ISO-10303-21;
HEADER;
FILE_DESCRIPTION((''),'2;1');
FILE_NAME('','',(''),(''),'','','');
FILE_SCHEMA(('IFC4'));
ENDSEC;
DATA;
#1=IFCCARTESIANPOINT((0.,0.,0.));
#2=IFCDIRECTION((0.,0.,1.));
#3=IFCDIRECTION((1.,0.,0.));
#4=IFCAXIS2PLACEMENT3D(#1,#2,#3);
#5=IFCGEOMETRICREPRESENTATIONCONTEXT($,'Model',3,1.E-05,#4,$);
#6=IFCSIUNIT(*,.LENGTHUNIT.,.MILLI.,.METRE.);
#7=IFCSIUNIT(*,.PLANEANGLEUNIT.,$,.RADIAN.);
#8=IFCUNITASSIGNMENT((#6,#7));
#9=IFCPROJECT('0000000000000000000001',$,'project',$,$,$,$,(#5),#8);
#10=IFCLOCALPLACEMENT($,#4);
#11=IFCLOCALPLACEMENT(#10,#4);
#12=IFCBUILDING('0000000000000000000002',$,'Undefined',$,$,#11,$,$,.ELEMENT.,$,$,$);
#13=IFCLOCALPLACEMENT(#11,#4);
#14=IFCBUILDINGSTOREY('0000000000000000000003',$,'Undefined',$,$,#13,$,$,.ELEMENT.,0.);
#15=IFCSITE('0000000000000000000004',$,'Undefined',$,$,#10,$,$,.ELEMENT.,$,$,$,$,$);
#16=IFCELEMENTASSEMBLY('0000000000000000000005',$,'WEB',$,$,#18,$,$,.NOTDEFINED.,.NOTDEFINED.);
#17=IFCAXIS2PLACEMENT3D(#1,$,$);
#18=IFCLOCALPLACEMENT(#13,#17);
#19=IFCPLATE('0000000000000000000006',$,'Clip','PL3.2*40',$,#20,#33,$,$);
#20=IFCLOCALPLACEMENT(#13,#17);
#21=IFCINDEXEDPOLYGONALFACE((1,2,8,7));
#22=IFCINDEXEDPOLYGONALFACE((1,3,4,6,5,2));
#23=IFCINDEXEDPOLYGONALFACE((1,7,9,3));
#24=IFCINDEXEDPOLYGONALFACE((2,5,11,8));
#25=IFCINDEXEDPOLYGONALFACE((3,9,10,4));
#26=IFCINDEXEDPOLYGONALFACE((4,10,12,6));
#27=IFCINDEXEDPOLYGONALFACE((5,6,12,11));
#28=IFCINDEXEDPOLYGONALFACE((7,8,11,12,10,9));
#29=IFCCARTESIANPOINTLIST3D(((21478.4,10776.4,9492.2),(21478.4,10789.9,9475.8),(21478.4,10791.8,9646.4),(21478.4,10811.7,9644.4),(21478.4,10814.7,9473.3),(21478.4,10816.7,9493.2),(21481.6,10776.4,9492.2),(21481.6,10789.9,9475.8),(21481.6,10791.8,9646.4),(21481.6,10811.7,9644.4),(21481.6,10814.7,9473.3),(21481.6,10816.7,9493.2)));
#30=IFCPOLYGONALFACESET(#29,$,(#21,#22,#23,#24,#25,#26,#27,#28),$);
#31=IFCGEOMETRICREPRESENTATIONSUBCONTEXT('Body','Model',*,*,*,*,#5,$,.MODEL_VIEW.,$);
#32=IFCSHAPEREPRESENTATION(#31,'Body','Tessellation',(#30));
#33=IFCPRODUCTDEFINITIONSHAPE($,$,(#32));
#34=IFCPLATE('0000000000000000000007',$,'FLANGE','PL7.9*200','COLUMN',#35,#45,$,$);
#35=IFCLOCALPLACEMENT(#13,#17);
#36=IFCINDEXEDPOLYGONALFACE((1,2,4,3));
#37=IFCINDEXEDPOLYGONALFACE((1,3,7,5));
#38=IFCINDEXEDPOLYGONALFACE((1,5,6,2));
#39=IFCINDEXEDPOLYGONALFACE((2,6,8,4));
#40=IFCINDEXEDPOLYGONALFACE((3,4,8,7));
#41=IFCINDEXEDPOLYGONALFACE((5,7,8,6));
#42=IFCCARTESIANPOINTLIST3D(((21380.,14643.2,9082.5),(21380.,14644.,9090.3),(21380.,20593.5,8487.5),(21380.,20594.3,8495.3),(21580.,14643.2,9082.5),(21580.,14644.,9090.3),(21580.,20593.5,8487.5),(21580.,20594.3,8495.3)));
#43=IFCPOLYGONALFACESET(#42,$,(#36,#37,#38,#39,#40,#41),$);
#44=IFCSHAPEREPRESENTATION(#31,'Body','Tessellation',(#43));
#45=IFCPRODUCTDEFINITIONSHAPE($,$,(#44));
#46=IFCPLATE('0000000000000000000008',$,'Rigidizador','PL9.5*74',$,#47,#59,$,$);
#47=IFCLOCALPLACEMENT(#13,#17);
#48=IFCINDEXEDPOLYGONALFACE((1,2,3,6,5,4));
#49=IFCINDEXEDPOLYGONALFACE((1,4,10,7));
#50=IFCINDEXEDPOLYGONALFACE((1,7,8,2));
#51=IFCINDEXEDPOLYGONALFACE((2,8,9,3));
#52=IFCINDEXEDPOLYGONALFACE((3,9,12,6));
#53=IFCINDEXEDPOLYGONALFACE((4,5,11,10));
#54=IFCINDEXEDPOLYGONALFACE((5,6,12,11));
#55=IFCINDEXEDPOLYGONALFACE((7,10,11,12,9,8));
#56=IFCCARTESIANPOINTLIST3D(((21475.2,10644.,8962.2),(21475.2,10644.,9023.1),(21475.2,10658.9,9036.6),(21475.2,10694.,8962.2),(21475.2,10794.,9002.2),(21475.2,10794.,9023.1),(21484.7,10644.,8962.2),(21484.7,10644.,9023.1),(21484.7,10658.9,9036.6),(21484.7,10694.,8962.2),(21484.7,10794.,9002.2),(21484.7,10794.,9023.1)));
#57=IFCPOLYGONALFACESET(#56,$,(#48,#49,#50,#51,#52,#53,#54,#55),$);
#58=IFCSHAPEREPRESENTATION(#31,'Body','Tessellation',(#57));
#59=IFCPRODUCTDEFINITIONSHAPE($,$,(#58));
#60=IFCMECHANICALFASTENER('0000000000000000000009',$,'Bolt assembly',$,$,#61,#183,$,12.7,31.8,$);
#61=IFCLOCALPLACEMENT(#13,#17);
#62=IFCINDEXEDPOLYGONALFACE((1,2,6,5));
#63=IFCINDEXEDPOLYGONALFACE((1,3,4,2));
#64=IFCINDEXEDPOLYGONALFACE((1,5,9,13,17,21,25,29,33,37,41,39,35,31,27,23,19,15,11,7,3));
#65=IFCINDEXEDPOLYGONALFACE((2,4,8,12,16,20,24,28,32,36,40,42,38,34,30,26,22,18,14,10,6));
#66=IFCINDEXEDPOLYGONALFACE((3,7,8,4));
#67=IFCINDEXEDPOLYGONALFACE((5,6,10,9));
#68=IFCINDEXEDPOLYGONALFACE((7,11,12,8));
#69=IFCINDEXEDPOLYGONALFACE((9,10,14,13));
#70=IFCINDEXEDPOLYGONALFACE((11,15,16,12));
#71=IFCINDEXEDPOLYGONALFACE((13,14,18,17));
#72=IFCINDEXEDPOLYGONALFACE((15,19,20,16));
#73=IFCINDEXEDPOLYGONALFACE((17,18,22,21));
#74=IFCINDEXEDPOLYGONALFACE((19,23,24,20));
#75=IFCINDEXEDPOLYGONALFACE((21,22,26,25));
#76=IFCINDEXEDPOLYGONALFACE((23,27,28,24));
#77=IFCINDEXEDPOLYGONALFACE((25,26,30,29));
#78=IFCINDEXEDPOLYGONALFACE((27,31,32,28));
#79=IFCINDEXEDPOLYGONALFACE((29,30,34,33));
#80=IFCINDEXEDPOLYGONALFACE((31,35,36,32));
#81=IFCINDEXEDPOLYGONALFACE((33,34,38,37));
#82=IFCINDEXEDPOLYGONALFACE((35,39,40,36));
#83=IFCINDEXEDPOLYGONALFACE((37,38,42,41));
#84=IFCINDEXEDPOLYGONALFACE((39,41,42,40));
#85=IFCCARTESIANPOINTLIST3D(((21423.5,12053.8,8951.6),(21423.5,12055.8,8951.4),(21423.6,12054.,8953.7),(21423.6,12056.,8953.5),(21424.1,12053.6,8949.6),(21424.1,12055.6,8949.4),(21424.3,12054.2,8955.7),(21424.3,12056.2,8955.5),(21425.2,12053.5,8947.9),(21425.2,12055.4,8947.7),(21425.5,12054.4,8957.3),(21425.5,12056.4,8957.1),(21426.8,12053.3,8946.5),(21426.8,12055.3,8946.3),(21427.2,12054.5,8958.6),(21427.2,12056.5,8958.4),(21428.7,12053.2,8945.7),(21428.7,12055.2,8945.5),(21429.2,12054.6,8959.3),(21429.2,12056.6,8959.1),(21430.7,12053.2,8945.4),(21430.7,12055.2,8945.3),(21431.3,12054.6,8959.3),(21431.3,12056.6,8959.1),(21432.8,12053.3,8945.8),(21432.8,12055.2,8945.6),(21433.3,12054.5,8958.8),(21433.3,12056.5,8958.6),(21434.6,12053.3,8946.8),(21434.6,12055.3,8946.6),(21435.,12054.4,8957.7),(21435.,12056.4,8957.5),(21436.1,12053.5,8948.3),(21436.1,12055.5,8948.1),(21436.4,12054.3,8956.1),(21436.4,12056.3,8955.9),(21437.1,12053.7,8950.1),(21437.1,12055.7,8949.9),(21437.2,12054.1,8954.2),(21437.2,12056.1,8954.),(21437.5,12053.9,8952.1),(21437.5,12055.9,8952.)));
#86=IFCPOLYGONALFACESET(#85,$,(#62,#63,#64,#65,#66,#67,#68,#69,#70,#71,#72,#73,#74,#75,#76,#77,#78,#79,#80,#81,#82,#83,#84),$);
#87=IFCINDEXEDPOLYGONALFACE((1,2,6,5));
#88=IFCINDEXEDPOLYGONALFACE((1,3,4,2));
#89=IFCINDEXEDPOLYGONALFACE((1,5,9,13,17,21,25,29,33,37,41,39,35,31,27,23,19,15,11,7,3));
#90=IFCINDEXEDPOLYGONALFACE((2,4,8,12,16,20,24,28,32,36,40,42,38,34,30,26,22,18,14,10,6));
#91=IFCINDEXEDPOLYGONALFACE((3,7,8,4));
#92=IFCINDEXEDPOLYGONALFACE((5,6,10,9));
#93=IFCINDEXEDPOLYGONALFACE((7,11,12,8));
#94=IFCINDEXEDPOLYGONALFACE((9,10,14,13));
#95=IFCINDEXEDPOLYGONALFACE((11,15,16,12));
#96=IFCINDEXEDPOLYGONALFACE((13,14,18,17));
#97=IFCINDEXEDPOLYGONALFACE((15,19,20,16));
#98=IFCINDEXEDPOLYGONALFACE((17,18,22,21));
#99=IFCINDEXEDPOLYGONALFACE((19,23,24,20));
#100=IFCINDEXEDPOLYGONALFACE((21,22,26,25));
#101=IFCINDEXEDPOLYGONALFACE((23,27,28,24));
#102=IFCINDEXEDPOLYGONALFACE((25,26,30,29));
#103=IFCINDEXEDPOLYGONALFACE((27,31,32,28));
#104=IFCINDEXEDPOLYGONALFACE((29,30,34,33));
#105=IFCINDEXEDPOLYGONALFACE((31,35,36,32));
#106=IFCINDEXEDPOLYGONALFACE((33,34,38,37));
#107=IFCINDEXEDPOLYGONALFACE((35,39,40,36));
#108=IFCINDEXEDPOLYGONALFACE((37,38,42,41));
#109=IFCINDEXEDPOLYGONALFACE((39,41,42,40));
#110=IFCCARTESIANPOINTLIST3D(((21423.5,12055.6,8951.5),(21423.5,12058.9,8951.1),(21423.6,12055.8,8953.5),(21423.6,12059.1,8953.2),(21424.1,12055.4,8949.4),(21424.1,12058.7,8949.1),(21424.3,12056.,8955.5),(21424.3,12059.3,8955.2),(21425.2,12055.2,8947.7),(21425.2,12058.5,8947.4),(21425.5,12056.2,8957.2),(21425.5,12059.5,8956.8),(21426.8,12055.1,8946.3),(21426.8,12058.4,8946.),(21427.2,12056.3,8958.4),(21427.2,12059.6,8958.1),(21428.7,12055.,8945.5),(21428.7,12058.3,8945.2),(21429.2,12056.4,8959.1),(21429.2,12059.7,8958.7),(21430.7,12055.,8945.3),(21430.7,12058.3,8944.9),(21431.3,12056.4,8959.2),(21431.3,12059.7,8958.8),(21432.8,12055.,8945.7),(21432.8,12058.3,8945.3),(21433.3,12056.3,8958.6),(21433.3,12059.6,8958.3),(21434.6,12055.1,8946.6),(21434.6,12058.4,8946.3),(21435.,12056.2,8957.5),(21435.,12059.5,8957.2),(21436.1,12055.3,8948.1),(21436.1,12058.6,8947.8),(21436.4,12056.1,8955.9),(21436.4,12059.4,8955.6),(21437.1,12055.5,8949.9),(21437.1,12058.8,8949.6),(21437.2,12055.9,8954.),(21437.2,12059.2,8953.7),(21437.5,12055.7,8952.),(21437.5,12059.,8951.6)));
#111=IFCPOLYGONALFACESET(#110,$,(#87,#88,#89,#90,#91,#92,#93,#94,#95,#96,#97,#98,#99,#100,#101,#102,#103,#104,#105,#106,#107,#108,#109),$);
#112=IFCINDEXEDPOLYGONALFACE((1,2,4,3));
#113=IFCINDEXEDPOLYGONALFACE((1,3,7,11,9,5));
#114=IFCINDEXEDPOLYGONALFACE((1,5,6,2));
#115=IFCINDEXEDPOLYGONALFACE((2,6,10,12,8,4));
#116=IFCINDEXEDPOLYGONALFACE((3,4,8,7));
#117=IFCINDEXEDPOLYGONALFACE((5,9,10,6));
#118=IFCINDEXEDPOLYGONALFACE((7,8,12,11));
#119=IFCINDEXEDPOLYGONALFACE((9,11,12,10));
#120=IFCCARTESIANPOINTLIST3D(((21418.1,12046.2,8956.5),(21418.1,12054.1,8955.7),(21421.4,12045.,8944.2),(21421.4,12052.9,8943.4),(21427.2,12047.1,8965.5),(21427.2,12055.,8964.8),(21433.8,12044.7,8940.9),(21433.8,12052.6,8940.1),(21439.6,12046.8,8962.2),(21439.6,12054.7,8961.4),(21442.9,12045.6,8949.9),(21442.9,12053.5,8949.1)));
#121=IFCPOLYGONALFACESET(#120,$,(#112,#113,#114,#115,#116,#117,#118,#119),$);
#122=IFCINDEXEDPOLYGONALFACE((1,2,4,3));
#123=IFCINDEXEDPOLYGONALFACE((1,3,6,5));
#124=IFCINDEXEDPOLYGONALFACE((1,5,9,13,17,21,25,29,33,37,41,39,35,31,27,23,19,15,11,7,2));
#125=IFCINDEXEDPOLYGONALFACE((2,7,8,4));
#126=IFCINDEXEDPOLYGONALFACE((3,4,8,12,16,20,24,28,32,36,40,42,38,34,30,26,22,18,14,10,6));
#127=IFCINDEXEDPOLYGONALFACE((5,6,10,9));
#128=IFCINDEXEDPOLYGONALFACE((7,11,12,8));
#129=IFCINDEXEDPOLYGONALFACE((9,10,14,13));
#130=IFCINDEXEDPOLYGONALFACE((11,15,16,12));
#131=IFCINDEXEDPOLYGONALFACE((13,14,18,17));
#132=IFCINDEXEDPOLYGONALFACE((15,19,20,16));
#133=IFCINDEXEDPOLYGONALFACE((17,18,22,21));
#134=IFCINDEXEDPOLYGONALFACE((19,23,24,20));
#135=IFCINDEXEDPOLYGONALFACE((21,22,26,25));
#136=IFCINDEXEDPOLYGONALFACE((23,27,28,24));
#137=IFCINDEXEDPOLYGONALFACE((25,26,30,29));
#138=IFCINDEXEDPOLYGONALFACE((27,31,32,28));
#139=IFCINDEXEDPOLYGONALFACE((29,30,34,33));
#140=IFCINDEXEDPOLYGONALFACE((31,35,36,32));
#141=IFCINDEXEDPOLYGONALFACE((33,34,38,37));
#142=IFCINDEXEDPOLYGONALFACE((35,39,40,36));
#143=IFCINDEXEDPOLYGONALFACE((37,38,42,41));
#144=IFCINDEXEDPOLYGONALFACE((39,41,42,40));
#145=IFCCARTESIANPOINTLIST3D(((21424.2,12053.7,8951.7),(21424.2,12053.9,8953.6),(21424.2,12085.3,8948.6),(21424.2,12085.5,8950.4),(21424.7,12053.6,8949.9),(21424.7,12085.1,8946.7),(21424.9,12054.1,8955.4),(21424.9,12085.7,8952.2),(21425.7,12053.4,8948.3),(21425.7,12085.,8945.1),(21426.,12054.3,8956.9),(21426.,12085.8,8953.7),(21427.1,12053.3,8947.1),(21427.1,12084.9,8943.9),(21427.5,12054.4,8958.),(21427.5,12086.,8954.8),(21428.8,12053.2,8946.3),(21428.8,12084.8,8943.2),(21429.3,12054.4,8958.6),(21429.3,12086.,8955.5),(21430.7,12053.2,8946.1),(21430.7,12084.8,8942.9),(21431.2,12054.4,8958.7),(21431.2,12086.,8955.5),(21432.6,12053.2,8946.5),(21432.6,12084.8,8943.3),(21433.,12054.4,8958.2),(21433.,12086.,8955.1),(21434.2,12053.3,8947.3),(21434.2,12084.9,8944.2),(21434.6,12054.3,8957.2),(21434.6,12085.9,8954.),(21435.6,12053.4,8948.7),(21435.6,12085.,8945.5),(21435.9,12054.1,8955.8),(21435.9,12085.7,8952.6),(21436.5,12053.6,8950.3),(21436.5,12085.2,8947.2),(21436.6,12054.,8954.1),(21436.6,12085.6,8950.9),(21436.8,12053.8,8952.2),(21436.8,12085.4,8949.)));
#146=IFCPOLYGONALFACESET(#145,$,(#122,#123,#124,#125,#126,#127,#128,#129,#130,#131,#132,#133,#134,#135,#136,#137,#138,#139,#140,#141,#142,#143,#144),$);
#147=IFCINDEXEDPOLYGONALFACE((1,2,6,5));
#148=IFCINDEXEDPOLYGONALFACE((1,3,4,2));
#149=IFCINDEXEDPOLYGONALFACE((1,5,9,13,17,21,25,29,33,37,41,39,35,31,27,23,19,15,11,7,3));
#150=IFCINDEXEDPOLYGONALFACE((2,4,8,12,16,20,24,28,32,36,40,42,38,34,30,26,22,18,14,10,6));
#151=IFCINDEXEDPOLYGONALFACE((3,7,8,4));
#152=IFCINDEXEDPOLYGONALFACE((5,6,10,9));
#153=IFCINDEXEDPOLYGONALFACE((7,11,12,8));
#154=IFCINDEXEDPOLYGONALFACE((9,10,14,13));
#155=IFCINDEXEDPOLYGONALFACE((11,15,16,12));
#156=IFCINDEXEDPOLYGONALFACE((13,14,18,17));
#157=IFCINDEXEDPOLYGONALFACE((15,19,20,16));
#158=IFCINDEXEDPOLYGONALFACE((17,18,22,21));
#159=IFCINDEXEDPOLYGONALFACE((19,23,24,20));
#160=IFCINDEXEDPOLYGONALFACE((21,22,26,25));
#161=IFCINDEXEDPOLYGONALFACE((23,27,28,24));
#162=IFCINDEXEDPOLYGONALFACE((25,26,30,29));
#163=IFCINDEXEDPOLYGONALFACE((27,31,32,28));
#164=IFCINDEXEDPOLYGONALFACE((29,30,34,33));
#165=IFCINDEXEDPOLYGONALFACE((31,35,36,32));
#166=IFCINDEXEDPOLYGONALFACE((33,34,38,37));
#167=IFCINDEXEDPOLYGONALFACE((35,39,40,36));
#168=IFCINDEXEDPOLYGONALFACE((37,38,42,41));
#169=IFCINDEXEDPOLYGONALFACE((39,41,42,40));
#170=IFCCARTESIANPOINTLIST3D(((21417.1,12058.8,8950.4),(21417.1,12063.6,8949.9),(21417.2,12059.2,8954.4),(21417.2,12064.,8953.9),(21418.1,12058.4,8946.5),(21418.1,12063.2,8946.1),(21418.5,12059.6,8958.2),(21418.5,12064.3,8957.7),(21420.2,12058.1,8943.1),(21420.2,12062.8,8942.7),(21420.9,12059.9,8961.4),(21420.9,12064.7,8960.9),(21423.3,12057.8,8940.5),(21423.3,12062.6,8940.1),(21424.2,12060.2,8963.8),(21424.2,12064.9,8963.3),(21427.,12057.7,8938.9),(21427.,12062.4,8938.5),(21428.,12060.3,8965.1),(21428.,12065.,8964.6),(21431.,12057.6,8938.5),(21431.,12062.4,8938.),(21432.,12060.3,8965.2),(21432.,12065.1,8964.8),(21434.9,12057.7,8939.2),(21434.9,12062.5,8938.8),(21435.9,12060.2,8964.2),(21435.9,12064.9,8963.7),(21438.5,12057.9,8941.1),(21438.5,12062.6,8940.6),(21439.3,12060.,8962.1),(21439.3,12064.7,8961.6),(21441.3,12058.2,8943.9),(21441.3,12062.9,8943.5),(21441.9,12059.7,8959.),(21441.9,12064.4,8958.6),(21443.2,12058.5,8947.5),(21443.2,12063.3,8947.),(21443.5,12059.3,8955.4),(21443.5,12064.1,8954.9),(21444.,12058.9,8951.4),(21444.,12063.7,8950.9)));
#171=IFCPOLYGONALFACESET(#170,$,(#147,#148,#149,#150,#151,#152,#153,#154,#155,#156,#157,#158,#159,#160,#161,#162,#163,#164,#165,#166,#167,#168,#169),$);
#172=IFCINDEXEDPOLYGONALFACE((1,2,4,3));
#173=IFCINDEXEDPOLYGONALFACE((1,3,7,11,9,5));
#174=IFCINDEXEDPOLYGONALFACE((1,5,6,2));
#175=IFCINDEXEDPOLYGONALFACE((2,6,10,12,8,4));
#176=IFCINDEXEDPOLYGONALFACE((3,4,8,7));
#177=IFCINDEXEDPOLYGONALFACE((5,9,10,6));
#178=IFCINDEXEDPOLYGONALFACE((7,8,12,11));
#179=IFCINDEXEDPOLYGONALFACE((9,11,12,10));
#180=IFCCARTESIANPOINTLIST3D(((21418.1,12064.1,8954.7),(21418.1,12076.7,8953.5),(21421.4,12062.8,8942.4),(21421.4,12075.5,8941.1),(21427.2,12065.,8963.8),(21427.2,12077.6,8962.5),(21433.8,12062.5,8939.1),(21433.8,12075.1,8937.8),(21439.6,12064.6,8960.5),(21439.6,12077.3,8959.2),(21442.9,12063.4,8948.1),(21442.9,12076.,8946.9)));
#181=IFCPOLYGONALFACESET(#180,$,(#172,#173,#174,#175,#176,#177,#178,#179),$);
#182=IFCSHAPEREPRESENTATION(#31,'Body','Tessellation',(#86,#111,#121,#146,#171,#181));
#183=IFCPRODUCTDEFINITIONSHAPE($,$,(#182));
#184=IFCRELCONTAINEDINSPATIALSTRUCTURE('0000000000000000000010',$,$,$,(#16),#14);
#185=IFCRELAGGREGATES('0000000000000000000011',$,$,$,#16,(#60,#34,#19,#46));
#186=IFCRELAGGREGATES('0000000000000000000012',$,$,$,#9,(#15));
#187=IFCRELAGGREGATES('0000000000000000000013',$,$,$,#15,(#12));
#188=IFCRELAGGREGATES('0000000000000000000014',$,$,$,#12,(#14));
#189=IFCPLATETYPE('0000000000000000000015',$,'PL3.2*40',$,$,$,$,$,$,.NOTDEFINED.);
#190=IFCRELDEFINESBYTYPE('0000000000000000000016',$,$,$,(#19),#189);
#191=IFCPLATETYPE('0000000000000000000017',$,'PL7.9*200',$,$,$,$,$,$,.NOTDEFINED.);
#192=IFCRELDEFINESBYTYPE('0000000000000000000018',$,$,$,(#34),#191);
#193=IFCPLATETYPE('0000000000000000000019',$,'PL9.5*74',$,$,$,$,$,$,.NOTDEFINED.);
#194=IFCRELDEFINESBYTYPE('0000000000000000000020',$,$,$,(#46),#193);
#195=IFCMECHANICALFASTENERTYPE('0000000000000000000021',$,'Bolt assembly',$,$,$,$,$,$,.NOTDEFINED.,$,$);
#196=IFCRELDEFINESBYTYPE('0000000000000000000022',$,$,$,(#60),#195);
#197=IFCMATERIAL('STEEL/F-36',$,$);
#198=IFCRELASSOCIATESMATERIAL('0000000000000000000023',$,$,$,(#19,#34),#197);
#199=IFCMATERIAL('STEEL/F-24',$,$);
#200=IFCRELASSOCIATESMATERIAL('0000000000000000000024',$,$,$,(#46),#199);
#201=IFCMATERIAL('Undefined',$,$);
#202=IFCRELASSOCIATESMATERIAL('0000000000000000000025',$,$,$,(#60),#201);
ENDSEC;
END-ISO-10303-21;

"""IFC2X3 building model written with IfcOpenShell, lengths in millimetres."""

from ifc_helpers import new_model, si_unit, frame, origin_with_axes, origin_2d_with_axis, place, context, subcontext, project, spatial, polyline, circle, outline, extrude, source, transform, mapped, material, type_object, element, aggregate, save


model = new_model("IFC2X3")

# Units and contexts
model_context = context("Model", 3, precision=1e-05, world=origin_with_axes())
body_context = subcontext(model_context, "Body", "Model", "MODEL_VIEW")
ifc_project = project(units=[si_unit("LENGTHUNIT", "METRE", prefix="MILLI"), si_unit("PLANEANGLEUNIT", "RADIAN")], contexts=[model_context])

# Site, building, storey
site_placement = place(None, origin_with_axes())
site = spatial("IfcSite", under=ifc_project, at=site_placement, Name="Undefined", CompositionType="ELEMENT")
building_placement = place(site_placement, origin_with_axes())
building = spatial("IfcBuilding", under=site, at=building_placement, Name="Undefined", CompositionType="ELEMENT")
storey_placement = place(building_placement, origin_with_axes())
storey = spatial("IfcBuildingStorey", under=building, at=storey_placement, Name="Undefined", CompositionType="ELEMENT", Elevation=0.0)

# Element assembly, plates
assembly_1_placement = place(storey_placement, origin_with_axes())
assembly_1 = element("IfcElementAssembly", 1, at=assembly_1_placement, inside=storey, Name="WEB", AssemblyPlace="NOTDEFINED", PredefinedType="NOTDEFINED")
ifc_material_1 = material(Name="STEEL/F-36")
plate_type_1 = type_object("IfcPlateType", Name="PL3.2*40", PredefinedType="NOTDEFINED")
plate_1_placement = place(assembly_1_placement, frame((21480.0, 10831.6, 9642.5), z_axis=(1.0, 0.0, 0.0), x_axis=(0.0, -0.995038, 0.099501)))
plate_1 = element("IfcPlate", 2, at=plate_1_placement, type_object=plate_type_1, material=ifc_material_1, Name="Clip", Description="PL3.2*40", context=body_context, shape_type="SweptSolid", body=[
    extrude(outline(polyline([(0.0, 150.0), (20.0, 0.0), (40.0, 0.0), (40.0, 155.0), (25.0, 170.0), (0.0, 170.0), (0.0, 170.0), (0.0, 150.0)])), frame((0.0, 0.0, -1.6), z_axis=(0.0, 0.0, 1.0), x_axis=(1.0, 0.0, 0.0)), (0.0, 0.0, 1.0), 3.2),
])
plate_type_2 = type_object("IfcPlateType", Name="PL7.9*200", PredefinedType="NOTDEFINED")
plate_2_placement = place(assembly_1_placement, frame((21480.0, 14643.6, 9086.4), z_axis=(0.0, 0.099504, 0.995037), x_axis=(0.0, 0.995037, -0.099504)))
plate_2 = element("IfcPlate", 3, at=plate_2_placement, type_object=plate_type_2, material=ifc_material_1, Name="FLANGE", Description="PL7.9*200", ObjectType="COLUMN", context=body_context, shape_type="SweptSolid", body=[
    extrude(outline(polyline([(0.0, -100.0), (0.0, 100.0), (5980.0, 100.0), (5980.0, -100.0), (0.0, -100.0)])), frame((0.0, 0.0, -4.0), z_axis=(0.0, 0.0, 1.0), x_axis=(1.0, 0.0, 0.0)), (0.0, 0.0, 1.0), 7.9),
])
ifc_material_2 = material(Name="STEEL/F-24")
plate_type_3 = type_object("IfcPlateType", Name="PL9.5*74", PredefinedType="NOTDEFINED")
plate_3_placement = place(assembly_1_placement, frame((21480.0, 10794.0, 8962.2), z_axis=(-1.0, 0.0, 0.0), x_axis=(0.0, -1.0, 0.0)))
plate_3 = element("IfcPlate", 4, at=plate_3_placement, type_object=plate_type_3, material=ifc_material_2, Name="Rigidizador", Description="PL9.5*74", context=body_context, shape_type="SweptSolid", body=[
    extrude(outline(polyline([(0.0, 40.0), (100.0, 0.0), (150.0, 0.0), (150.0, 60.9), (135.1, 74.4), (0.0, 60.9), (0.0, 40.0)])), frame((0.0, 0.0, -4.7), z_axis=(0.0, 0.0, 1.0), x_axis=(1.0, 0.0, 0.0)), (0.0, 0.0, 1.0), 9.5),
])

# Shared definitions
ifc_material_3 = material(Name="Undefined")
mechanical_fastener_type = type_object("IfcMechanicalFastenerType", Name="Bolt assembly")

# Mechanical fastener
shared_shape_1 = source(origin_with_axes(), body_context, "Body", "SweptSolid", [
    extrude(circle(Radius=7.0, at=origin_2d_with_axis()), frame((0.0, -1.9, 0.0), z_axis=(0.0, 1.0, 0.0), x_axis=(1.0, 0.0, 0.0)), (0.0, 0.0, 1.0), 2.0),
    extrude(circle(Radius=7.0, at=origin_2d_with_axis()), frame((0.0, -0.1, 0.0), z_axis=(0.0, 1.0, 0.0), x_axis=(1.0, 0.0, 0.0)), (0.0, 0.0, 1.0), 3.3),
    extrude(outline(polyline([(11.1, -6.4), (11.1, 6.4), (0.0, 12.8), (-11.1, 6.4), (-11.1, -6.4), (0.0, -12.8), (11.1, -6.4)])), frame((0.0, -9.9, 0.0), z_axis=(0.0, 1.0, 0.0), x_axis=(1.0, 0.0, 0.0)), (0.0, 0.0, 1.0), 7.9),
    extrude(circle(Radius=6.3, at=origin_2d_with_axis()), frame((0.0, -2.0, 0.0), z_axis=(0.0, 1.0, 0.0), x_axis=(1.0, 0.0, 0.0)), (0.0, 0.0, 1.0), 31.8),
    extrude(circle(Radius=13.5, at=origin_2d_with_axis()), frame((0.0, 3.2, 0.0), z_axis=(0.0, 1.0, 0.0), x_axis=(1.0, 0.0, 0.0)), (0.0, 0.0, 1.0), 4.8),
    extrude(outline(polyline([(11.1, -6.4), (11.1, 6.4), (0.0, 12.8), (-11.1, 6.4), (-11.1, -6.4), (0.0, -12.8), (11.1, -6.4)])), frame((0.0, 8.0, 0.0), z_axis=(0.0, 1.0, 0.0), x_axis=(1.0, 0.0, 0.0)), (0.0, 0.0, 1.0), 12.7),
])
mechanical_fastener_1_placement = place(assembly_1_placement, frame((21430.5, 12055.8, 8952.2), z_axis=(-0.707107, -0.07036, -0.703598), x_axis=(-0.707107, 0.07036, 0.703598)))
mechanical_fastener_1 = element("IfcMechanicalFastener", 5, at=mechanical_fastener_1_placement, type_object=mechanical_fastener_type, material=ifc_material_3, Name="Bolt assembly", NominalDiameter=12.7, NominalLength=31.8, context=body_context, shape_type="MappedRepresentation", body=[
    mapped(shared_shape_1, transform((0.0, 0.0, 0.0))),
])
aggregate(assembly_1, [mechanical_fastener_1, plate_2, plate_1, plate_3])

save(model, "model.ifc")
